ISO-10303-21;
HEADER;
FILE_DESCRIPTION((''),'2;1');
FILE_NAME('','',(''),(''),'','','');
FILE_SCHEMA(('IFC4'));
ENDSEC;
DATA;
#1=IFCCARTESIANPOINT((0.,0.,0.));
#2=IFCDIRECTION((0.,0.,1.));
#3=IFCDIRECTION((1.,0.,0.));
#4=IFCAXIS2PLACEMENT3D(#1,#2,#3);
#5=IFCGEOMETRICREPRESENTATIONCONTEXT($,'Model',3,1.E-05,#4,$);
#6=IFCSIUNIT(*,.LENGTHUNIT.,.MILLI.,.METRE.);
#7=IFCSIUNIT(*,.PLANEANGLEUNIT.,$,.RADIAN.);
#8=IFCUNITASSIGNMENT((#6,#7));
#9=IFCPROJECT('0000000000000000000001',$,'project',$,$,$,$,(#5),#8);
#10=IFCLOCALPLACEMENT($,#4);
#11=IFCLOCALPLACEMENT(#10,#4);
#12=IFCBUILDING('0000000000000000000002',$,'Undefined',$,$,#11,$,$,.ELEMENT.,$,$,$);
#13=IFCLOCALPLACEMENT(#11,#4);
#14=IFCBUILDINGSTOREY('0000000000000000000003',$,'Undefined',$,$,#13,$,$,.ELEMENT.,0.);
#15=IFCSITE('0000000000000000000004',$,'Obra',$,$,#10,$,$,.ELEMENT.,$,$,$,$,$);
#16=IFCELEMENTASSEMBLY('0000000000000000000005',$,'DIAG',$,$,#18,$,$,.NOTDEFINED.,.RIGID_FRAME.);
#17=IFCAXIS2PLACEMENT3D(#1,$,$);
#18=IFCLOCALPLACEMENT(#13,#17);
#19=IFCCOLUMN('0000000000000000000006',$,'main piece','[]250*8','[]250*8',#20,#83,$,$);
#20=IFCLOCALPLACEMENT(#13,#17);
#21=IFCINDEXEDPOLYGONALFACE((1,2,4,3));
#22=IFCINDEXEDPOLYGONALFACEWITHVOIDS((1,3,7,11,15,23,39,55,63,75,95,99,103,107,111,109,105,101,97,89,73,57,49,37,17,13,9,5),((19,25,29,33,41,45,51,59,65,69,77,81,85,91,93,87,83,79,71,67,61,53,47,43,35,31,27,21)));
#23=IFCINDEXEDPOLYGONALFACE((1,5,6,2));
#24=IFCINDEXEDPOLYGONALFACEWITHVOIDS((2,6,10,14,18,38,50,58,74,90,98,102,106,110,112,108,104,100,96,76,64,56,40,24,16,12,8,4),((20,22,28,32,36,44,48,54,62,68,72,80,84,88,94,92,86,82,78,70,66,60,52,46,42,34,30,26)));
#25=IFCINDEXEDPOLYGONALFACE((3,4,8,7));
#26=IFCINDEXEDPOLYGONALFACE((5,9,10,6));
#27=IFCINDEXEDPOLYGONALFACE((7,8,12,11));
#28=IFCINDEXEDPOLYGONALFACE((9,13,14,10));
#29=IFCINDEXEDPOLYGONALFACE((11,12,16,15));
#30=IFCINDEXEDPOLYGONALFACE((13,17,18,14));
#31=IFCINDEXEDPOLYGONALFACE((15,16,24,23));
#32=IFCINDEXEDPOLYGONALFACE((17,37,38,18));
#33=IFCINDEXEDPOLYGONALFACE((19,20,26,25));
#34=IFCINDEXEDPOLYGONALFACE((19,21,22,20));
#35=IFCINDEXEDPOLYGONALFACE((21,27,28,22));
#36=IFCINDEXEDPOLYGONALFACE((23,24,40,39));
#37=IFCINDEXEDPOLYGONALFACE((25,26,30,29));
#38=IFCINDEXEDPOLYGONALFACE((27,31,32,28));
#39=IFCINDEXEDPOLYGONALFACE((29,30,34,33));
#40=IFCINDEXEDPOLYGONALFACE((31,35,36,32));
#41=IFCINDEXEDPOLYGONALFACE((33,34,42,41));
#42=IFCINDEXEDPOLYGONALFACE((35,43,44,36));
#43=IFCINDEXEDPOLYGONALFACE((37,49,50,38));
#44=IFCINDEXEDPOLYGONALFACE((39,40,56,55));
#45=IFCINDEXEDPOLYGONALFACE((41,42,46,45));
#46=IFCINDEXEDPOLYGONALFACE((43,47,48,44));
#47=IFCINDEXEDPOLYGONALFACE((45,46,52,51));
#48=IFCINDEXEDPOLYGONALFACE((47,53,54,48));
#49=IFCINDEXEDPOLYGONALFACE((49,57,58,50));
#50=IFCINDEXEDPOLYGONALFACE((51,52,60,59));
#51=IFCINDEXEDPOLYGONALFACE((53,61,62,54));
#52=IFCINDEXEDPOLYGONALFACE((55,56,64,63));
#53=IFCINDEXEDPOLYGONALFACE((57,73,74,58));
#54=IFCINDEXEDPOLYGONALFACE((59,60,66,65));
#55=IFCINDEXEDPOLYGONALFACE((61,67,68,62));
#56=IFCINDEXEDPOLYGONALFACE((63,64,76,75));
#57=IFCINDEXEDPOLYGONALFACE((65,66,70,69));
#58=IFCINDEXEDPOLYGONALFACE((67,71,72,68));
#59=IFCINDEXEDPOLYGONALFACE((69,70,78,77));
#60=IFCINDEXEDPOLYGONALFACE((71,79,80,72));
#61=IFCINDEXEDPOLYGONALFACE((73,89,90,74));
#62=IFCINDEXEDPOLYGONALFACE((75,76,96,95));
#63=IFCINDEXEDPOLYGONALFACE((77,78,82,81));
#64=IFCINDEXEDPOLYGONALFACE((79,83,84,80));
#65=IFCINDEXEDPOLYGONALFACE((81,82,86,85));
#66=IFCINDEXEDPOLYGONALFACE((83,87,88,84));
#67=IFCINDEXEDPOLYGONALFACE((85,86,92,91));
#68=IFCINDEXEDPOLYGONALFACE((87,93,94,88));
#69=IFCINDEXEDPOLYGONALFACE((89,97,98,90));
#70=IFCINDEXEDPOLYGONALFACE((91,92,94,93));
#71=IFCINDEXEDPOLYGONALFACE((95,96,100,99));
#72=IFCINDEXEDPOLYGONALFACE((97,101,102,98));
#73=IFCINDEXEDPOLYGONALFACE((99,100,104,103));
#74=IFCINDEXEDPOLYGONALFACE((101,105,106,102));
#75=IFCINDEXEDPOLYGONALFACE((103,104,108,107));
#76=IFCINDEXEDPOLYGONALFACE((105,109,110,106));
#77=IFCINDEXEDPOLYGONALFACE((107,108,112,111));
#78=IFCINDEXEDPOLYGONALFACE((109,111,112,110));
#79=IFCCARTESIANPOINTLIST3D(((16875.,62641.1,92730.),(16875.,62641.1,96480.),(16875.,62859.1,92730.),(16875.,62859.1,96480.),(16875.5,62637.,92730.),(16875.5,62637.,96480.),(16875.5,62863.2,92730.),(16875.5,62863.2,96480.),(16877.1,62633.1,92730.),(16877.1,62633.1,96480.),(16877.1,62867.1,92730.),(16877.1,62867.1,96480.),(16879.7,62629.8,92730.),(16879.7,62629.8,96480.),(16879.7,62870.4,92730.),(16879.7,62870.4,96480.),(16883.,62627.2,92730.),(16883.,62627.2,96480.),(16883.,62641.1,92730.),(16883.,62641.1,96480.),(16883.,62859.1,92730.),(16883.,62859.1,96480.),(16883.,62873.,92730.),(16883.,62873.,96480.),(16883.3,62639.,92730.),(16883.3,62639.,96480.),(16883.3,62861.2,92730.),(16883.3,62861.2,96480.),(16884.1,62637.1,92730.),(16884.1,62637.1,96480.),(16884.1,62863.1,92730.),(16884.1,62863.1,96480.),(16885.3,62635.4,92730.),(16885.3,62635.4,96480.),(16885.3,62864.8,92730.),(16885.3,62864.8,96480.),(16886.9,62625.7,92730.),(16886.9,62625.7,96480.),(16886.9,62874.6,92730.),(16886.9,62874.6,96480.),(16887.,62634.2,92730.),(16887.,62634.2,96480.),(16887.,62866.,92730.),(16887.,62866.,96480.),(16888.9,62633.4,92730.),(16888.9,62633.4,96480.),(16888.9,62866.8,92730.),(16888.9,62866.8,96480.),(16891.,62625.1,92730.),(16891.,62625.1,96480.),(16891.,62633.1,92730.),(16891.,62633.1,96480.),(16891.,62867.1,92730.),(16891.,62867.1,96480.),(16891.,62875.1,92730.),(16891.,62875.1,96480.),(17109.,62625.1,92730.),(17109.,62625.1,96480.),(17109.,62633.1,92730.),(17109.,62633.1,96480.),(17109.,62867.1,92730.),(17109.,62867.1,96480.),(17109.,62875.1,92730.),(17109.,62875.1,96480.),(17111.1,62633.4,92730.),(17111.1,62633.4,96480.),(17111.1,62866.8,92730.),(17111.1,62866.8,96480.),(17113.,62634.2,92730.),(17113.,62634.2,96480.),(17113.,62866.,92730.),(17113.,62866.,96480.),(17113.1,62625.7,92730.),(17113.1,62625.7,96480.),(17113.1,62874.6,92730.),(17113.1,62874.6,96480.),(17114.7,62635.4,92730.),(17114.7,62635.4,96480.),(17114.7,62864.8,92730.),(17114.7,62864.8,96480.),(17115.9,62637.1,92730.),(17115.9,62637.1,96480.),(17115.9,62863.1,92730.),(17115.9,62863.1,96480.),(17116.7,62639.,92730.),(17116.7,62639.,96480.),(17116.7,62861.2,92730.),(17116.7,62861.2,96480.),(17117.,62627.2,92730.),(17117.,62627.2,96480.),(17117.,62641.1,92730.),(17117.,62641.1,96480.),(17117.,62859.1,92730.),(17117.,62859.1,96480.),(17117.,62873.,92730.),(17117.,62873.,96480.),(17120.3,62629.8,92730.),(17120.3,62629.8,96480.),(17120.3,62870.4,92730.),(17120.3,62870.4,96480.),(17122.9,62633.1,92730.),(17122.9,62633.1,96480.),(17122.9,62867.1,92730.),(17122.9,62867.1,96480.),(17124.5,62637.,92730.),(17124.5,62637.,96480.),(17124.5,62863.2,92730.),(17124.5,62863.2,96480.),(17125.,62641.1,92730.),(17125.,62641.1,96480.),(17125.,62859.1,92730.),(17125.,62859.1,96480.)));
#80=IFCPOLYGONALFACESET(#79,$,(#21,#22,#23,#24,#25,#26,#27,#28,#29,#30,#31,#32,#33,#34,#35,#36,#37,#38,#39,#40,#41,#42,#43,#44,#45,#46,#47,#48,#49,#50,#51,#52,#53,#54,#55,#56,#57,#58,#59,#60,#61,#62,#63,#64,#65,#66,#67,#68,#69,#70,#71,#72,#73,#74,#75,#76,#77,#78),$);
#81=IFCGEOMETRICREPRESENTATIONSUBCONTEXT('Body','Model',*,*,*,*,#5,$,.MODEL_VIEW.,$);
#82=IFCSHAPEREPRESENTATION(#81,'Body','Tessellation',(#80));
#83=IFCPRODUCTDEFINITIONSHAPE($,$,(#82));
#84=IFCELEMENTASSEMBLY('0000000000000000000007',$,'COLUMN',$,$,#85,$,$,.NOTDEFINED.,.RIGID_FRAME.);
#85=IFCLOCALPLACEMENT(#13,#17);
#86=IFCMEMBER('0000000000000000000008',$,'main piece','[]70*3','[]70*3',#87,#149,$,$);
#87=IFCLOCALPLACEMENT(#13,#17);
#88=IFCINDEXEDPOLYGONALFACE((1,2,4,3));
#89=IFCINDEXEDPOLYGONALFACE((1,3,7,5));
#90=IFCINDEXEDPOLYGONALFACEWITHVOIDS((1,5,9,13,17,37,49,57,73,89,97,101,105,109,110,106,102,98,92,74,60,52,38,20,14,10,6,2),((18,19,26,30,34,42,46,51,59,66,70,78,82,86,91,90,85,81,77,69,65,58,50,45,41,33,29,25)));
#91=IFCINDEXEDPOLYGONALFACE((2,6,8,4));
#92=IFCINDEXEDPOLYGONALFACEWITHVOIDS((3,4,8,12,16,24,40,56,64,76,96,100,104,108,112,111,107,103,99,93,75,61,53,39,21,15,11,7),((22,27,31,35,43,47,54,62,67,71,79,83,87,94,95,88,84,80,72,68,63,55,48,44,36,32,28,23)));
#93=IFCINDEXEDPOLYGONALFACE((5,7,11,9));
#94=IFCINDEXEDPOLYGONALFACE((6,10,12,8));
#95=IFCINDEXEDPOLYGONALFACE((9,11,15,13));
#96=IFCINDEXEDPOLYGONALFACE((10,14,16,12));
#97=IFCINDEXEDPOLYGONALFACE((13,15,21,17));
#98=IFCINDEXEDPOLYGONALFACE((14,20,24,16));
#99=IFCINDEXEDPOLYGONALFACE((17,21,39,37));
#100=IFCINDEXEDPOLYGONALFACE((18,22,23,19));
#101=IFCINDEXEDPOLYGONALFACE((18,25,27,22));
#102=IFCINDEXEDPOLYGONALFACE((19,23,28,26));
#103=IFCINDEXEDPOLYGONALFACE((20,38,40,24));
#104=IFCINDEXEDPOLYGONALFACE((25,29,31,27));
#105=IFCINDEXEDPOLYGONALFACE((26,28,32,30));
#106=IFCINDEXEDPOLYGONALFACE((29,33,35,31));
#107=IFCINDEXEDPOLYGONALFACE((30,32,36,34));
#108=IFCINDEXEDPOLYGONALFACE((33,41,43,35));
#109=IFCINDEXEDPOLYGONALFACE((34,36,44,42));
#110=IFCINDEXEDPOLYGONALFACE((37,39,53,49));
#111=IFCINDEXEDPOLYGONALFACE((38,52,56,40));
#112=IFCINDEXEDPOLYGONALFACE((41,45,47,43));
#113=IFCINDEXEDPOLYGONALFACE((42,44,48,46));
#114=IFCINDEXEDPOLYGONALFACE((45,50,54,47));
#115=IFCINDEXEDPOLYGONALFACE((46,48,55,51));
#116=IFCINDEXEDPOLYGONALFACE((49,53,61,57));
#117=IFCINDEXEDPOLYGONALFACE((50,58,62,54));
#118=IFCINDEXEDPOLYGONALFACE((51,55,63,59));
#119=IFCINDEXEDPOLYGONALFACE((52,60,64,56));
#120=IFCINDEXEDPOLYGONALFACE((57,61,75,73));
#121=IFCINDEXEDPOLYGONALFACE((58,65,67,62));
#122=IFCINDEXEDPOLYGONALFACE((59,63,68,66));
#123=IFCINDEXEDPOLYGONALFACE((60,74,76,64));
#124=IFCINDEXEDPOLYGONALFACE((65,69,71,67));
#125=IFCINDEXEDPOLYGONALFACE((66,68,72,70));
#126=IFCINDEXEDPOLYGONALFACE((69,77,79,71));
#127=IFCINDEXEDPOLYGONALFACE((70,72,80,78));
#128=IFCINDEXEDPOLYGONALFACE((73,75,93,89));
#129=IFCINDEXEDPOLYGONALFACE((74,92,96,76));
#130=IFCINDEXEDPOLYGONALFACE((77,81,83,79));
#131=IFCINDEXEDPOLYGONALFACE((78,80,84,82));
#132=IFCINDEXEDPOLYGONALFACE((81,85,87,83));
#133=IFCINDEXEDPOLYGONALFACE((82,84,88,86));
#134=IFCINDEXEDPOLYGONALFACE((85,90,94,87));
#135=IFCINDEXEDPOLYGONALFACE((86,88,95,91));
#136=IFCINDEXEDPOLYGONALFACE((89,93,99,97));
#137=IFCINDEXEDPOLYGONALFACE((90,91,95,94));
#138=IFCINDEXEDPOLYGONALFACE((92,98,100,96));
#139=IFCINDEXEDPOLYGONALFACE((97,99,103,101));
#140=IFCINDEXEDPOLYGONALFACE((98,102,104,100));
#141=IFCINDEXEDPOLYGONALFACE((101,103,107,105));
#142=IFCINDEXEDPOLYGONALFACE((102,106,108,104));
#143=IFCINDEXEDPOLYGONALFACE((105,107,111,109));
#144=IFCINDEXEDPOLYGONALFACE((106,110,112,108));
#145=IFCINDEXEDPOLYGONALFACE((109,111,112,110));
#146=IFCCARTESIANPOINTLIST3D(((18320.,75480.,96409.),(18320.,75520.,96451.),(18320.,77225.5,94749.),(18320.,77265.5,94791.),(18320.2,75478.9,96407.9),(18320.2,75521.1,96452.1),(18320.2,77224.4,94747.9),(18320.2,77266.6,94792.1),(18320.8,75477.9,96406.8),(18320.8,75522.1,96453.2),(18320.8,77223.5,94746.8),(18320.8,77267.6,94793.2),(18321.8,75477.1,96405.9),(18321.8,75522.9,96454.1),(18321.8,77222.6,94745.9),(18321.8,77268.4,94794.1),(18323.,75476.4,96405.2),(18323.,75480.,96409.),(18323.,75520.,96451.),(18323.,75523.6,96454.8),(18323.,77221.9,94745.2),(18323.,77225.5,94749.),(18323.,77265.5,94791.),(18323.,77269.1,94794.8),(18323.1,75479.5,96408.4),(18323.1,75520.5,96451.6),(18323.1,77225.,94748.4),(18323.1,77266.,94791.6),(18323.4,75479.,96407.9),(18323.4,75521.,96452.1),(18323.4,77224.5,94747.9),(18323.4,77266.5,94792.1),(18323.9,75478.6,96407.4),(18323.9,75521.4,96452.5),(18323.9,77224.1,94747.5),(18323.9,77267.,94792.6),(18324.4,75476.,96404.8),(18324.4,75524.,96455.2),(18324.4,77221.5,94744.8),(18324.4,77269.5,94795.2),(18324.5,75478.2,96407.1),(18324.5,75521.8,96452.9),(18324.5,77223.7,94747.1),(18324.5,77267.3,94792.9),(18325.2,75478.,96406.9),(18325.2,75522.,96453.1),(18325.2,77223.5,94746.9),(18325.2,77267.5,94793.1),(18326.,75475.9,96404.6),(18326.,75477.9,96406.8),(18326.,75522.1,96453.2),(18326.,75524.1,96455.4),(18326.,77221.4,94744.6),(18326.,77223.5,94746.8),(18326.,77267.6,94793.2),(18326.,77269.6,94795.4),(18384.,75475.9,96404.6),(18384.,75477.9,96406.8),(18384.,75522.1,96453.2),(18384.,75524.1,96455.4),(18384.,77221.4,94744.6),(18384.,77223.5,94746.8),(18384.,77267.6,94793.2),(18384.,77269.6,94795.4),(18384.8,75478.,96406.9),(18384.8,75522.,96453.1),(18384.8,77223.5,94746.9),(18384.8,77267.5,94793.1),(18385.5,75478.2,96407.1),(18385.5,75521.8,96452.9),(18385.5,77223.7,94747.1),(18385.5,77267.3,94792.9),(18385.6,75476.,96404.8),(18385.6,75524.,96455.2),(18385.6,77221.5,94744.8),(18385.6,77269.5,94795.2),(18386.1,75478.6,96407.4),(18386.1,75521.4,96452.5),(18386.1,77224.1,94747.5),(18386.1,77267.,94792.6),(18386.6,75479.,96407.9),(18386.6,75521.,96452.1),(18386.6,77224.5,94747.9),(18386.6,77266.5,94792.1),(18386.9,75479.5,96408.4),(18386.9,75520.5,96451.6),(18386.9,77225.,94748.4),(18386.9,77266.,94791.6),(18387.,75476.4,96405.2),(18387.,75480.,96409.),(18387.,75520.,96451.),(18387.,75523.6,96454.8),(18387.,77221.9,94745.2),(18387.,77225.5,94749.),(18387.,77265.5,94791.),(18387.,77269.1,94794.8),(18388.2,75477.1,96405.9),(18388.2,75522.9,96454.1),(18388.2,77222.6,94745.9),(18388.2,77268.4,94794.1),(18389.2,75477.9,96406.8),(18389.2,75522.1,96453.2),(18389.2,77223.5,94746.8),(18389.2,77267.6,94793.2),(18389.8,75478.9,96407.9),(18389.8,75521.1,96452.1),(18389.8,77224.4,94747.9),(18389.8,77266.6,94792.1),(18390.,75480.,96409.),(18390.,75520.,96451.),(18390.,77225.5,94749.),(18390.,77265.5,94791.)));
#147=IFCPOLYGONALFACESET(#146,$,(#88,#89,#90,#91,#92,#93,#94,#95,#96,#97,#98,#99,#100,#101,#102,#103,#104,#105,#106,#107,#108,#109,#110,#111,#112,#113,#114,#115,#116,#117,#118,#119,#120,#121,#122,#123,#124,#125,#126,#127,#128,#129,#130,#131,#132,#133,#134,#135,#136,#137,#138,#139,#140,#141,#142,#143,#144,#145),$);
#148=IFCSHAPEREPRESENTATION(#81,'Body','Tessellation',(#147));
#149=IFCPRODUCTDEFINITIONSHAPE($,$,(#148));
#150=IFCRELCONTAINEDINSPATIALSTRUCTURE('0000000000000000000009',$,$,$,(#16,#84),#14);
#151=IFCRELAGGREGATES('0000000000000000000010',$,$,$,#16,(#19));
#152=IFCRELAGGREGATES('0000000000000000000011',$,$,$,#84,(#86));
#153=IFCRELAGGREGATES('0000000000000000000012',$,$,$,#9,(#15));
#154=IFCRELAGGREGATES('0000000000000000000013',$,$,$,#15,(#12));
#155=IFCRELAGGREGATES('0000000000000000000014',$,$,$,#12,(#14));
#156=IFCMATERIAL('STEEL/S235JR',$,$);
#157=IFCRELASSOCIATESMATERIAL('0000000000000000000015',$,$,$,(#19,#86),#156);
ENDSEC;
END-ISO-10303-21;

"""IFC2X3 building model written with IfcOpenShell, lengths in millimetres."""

from ifc_helpers import new_model, si_unit, frame, origin_with_axes, origin_2d_with_axis, place, context, subcontext, project, spatial, hollow_rectangle, extrude, material, element, aggregate, save


model = new_model("IFC2X3")

# Units and contexts
model_context = context("Model", 3, precision=1e-05, world=origin_with_axes())
body_context = subcontext(model_context, "Body", "Model", "MODEL_VIEW")
ifc_project = project(units=[si_unit("LENGTHUNIT", "METRE", prefix="MILLI"), si_unit("PLANEANGLEUNIT", "RADIAN")], contexts=[model_context])

# Site, building, storey
site_placement = place(None, origin_with_axes())
site = spatial("IfcSite", under=ifc_project, at=site_placement, Name="Obra", CompositionType="ELEMENT")
building_placement = place(site_placement, origin_with_axes())
building = spatial("IfcBuilding", under=site, at=building_placement, Name="Undefined", CompositionType="ELEMENT")
storey_placement = place(building_placement, origin_with_axes())
storey = spatial("IfcBuildingStorey", under=building, at=storey_placement, Name="Undefined", CompositionType="ELEMENT", Elevation=0.0)

# Element assembly, column
ifc_material = material(Name="STEEL/S235JR")
assembly_1_placement = place(storey_placement, origin_with_axes())
assembly_1 = element("IfcElementAssembly", 1, at=assembly_1_placement, inside=storey, Name="DIAG", AssemblyPlace="NOTDEFINED", PredefinedType="RIGID_FRAME")
column_1_placement = place(assembly_1_placement, frame((17000.0, 62750.1, 92730.0), z_axis=(0.0, 0.0, 1.0), x_axis=(-1.0, 0.0, 0.0)))
column_1 = element("IfcColumn", 2, at=column_1_placement, material=ifc_material, Name="main piece", Description="[]250*8", ObjectType="[]250*8", context=body_context, shape_type="SweptSolid", body=[
    extrude(hollow_rectangle(XDim=250.0, YDim=250.0, WallThickness=8.0, InnerFilletRadius=8.0, OuterFilletRadius=16.0, at=origin_2d_with_axis()), frame((0.0, 0.0, 3750.0), z_axis=(0.0, 0.0, -1.0), x_axis=(0.0, 1.0, 0.0)), (0.0, 0.0, 1.0), 3750.0),
])
aggregate(assembly_1, [column_1])

# Element assembly, member
assembly_2_placement = place(storey_placement, origin_with_axes())
assembly_2 = element("IfcElementAssembly", 3, at=assembly_2_placement, inside=storey, Name="COLUMN", AssemblyPlace="NOTDEFINED", PredefinedType="RIGID_FRAME")
member_1_placement = place(assembly_2_placement, frame((18355.0, 77245.5, 94770.0), z_axis=(1.0, 0.0, 0.0), x_axis=(0.0, -0.724633, 0.689135)))
member_1 = element("IfcMember", 4, at=member_1_placement, material=ifc_material, Name="main piece", Description="[]70*3", ObjectType="[]70*3", context=body_context, shape_type="SweptSolid", body=[
    extrude(hollow_rectangle(XDim=70.0, YDim=70.0, WallThickness=3.0, InnerFilletRadius=3.0, OuterFilletRadius=6.0, at=origin_2d_with_axis()), frame((2408.8, 0.0, 0.0), z_axis=(-1.0, 0.0, 0.0), x_axis=(0.0, -1.0, 0.0)), (0.0, 0.0, 1.0), 2408.8),
])
aggregate(assembly_2, [member_1])

save(model, "model.ifc")
